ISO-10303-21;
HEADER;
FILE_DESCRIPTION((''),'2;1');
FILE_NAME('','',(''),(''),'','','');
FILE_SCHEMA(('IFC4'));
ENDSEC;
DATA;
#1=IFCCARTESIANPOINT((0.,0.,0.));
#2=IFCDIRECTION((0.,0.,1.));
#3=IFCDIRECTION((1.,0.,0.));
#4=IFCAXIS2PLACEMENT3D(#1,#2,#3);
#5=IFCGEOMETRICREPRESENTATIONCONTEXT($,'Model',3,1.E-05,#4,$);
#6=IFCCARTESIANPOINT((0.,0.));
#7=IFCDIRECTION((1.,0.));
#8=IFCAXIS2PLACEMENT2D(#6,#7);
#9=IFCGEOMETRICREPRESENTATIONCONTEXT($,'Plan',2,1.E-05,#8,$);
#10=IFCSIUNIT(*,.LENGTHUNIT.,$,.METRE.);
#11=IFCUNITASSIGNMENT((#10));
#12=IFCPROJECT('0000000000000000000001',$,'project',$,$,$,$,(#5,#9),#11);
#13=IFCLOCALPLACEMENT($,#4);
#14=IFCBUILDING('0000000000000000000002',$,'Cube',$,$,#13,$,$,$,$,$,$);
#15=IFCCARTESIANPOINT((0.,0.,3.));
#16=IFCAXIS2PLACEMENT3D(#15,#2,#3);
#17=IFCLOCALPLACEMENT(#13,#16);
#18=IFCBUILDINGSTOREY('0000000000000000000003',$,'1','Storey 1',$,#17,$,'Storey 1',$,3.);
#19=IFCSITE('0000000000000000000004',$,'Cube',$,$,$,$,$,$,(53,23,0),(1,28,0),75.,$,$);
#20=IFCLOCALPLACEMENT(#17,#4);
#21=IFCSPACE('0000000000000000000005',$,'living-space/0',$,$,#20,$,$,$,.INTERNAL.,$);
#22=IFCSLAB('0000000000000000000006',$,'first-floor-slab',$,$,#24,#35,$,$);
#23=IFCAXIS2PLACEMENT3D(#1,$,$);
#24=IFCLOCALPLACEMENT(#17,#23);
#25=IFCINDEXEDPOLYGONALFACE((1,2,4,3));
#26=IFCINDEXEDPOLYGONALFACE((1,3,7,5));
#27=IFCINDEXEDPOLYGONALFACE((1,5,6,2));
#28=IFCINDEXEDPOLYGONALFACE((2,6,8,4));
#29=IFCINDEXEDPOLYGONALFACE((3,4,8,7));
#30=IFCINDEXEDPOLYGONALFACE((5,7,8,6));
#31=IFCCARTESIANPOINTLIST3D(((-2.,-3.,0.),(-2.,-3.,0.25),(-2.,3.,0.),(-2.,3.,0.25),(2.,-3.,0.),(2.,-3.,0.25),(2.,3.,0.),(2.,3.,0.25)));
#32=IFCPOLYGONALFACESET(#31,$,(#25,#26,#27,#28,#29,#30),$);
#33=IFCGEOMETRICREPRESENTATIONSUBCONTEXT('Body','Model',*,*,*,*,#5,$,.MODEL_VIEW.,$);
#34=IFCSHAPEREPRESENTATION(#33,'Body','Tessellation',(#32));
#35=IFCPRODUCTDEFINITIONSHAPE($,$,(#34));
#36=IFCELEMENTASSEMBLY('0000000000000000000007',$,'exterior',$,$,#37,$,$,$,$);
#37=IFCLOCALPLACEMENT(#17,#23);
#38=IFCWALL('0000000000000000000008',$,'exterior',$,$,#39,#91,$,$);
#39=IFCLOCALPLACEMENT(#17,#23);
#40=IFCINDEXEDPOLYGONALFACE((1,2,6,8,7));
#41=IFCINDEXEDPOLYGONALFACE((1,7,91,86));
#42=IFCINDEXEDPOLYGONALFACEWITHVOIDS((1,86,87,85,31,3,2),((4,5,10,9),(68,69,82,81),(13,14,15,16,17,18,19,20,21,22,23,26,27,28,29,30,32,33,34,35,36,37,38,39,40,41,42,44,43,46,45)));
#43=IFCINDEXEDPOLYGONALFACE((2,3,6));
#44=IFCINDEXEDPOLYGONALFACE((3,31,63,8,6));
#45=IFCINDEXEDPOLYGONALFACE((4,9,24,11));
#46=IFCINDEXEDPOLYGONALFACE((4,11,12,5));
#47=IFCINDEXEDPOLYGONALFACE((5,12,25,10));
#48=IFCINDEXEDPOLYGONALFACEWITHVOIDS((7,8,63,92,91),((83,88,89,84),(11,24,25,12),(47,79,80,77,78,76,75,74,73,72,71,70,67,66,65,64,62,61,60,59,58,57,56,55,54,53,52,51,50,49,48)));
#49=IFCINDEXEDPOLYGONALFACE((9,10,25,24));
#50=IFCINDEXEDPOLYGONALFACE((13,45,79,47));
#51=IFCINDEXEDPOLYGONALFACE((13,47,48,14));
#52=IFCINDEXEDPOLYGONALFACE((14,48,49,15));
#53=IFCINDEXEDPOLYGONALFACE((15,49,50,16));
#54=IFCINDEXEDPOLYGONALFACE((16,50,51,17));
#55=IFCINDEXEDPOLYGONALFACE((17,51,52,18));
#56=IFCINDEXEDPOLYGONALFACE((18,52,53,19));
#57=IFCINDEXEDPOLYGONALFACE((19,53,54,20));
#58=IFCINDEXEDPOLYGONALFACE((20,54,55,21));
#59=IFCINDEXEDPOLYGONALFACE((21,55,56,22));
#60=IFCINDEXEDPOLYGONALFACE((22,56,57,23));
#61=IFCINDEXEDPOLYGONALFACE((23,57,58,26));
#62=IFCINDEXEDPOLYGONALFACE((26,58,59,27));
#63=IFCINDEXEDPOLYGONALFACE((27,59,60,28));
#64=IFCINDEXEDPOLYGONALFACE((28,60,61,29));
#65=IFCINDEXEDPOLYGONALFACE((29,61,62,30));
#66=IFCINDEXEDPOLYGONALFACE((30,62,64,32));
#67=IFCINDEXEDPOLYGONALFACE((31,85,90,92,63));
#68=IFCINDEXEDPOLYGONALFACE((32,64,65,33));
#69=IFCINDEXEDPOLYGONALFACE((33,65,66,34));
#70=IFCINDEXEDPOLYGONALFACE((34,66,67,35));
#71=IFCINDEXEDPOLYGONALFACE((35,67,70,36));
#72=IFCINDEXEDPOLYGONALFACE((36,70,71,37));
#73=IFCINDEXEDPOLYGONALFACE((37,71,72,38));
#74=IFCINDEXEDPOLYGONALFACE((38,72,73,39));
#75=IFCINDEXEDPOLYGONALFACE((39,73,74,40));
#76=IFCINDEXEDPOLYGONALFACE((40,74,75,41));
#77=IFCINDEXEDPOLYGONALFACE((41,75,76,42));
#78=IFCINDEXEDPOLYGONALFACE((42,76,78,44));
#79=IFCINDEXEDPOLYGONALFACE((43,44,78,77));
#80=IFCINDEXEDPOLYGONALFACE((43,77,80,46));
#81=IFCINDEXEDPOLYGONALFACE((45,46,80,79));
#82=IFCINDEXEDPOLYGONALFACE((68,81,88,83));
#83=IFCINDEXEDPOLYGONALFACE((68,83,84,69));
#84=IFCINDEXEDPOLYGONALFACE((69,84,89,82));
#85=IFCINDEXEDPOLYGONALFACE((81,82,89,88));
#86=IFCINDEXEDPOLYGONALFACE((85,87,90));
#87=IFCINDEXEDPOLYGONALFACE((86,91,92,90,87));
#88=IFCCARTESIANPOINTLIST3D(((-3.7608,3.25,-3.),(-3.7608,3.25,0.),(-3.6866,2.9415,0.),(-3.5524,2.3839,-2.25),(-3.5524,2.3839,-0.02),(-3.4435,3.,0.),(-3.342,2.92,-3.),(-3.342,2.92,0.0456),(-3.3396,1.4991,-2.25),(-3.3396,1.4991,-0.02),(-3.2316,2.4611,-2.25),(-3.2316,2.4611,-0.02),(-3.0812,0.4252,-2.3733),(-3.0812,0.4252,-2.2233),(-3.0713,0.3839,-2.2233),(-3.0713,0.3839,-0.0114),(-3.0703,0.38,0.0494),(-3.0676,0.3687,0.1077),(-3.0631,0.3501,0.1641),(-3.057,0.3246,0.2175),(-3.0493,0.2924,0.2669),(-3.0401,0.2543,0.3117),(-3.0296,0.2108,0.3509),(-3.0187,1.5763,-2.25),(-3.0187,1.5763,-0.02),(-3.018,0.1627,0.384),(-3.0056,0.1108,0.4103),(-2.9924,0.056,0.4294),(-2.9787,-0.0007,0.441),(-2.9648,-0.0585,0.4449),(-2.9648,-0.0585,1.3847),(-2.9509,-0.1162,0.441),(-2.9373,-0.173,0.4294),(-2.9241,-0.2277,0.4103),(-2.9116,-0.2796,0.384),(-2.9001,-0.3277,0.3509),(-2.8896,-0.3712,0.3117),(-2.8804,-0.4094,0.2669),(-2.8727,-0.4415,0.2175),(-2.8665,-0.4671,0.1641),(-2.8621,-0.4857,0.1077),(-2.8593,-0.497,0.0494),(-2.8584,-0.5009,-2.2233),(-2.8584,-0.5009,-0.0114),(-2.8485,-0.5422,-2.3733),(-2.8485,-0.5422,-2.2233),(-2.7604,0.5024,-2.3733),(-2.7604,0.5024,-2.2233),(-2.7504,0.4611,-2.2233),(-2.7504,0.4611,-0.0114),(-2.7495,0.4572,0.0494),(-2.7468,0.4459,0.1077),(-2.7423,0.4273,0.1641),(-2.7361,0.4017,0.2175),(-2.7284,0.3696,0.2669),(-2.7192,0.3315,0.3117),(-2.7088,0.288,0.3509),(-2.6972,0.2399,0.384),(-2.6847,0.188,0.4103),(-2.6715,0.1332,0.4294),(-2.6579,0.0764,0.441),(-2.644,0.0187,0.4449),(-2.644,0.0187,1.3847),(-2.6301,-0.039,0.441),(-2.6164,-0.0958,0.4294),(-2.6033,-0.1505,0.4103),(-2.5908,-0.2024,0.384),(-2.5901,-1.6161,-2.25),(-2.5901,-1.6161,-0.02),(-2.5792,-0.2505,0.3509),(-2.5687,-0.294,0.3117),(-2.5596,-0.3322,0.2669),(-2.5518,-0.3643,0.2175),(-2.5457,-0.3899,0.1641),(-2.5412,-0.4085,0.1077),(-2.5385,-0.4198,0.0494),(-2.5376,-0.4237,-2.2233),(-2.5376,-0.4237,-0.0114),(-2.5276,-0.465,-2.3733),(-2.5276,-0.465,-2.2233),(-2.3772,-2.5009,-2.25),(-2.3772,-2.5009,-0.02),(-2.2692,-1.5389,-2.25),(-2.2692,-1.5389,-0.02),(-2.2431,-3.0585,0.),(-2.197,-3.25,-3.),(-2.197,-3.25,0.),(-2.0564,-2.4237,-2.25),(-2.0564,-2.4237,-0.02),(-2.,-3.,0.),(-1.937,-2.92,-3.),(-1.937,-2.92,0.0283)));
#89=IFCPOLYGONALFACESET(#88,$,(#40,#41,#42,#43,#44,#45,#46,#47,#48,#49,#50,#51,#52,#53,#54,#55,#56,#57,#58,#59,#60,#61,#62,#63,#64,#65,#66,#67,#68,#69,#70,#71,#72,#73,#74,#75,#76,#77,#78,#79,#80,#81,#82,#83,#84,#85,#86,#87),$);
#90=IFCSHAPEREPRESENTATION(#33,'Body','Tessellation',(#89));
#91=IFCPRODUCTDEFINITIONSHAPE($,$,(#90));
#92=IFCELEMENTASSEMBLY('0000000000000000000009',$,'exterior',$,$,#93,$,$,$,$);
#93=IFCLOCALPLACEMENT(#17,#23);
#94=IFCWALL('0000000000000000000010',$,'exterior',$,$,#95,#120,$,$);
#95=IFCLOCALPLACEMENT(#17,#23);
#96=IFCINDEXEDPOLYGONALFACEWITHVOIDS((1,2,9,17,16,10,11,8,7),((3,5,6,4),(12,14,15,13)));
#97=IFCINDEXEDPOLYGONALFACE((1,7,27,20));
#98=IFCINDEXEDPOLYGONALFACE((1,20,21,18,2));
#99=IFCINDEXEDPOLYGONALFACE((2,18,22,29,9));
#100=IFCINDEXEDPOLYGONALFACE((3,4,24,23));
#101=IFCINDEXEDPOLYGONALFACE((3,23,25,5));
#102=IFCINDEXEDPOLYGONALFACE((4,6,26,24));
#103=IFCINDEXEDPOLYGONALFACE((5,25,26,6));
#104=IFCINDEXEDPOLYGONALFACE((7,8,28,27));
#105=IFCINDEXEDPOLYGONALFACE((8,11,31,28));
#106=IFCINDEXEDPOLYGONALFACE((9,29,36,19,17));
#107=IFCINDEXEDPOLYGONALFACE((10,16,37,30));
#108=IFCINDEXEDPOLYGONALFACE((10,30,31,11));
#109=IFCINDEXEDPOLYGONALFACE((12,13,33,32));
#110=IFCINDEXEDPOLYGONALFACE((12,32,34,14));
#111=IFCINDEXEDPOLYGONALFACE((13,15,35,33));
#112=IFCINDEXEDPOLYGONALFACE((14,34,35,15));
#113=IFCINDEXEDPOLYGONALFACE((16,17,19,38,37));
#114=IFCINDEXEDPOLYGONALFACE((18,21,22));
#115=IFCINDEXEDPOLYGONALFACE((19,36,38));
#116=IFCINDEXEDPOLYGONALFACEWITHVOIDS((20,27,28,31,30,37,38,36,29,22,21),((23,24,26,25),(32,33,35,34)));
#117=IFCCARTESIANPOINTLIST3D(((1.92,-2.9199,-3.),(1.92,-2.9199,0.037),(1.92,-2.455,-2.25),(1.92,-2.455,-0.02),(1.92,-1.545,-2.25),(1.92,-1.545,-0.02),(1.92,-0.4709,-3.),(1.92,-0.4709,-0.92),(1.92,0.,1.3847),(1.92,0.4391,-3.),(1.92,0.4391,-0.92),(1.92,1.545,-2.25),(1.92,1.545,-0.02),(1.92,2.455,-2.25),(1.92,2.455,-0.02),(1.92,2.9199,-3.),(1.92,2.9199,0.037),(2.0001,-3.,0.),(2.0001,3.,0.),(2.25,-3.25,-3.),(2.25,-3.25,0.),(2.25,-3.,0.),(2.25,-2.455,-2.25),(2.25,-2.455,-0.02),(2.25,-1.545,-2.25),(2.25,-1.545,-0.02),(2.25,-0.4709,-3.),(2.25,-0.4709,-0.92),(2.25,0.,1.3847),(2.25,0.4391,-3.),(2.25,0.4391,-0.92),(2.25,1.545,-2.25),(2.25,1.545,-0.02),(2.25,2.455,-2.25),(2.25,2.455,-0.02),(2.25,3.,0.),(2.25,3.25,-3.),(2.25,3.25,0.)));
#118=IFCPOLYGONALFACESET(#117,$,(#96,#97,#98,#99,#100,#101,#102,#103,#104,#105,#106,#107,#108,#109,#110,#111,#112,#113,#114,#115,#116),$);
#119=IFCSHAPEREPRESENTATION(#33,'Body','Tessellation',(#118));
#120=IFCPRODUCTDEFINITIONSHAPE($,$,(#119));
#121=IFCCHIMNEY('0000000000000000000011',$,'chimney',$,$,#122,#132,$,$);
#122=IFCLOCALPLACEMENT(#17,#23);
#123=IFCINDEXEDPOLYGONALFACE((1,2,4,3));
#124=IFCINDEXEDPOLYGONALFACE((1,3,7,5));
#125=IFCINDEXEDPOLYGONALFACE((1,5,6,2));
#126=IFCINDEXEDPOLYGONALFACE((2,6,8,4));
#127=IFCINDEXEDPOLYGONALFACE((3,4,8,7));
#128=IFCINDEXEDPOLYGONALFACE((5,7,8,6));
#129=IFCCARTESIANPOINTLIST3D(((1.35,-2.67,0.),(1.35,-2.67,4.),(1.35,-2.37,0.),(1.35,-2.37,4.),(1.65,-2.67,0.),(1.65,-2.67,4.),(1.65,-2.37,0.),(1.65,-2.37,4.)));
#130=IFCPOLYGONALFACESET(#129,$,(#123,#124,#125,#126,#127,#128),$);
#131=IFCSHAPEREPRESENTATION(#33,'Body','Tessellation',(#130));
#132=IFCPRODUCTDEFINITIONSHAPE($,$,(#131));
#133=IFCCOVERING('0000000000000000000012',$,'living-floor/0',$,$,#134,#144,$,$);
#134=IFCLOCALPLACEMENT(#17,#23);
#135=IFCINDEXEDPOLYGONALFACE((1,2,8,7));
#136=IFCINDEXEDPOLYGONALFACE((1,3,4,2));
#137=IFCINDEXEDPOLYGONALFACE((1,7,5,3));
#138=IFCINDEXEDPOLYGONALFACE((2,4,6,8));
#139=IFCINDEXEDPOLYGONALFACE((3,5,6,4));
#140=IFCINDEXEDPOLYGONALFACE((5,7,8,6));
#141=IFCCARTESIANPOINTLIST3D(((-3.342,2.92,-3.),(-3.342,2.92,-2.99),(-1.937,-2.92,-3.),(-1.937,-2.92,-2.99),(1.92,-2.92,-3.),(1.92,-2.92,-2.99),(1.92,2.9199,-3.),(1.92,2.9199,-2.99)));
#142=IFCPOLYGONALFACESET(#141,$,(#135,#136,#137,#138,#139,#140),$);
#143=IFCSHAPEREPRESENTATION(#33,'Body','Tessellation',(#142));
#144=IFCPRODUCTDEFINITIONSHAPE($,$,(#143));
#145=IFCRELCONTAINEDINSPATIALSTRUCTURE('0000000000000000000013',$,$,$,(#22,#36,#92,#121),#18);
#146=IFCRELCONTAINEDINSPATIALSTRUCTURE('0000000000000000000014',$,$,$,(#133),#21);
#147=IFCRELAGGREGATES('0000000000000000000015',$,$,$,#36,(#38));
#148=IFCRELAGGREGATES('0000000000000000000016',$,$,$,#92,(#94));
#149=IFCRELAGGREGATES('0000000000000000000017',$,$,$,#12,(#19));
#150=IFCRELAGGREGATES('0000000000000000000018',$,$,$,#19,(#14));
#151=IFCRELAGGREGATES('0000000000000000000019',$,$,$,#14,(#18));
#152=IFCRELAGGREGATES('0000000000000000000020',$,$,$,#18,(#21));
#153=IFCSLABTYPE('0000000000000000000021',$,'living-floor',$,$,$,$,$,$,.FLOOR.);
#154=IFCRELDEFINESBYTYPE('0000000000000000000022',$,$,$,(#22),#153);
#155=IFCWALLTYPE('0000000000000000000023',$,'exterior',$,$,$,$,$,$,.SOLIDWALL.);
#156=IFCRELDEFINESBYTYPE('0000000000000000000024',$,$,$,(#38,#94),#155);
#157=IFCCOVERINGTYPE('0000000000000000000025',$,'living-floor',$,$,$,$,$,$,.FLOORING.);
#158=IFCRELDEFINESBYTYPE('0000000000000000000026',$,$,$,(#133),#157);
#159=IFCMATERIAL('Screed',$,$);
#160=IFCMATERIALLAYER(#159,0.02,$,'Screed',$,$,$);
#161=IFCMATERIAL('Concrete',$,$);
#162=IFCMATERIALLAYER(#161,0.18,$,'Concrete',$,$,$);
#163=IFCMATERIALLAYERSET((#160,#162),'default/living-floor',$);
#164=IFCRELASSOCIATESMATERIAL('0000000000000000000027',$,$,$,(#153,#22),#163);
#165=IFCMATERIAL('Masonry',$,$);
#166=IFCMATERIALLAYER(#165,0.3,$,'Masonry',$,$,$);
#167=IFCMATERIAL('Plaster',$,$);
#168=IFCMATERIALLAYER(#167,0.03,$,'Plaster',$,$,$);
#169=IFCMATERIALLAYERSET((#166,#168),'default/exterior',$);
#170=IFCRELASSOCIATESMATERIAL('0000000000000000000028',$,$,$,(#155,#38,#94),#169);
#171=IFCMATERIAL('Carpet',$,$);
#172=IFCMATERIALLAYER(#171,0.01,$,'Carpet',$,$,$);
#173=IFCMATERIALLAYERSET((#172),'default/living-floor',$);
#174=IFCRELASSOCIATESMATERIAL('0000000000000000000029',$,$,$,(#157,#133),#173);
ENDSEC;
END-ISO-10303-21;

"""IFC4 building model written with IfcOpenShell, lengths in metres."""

from ifc_helpers import new_model, si_unit, frame, origin, origin_with_axes, origin_2d_with_axis, place, context, subcontext, project, spatial, polyline, line, indexed_curve, outline, extrude, clip, bounded_halfspace, source, transform, mapped, material, layer, layer_set, layer_usage, type_object, element, aggregate, save


model = new_model("IFC4")

# Units and contexts
model_context = context("Model", 3, precision=1e-05, world=origin_with_axes())
plan_context = context("Plan", 2, precision=1e-05, world=origin_2d_with_axis())
body_context_1 = subcontext(model_context, "Body", "Model", "MODEL_VIEW")
ifc_project = project(units=[si_unit("LENGTHUNIT", "METRE")], contexts=[model_context, plan_context])

# Site, building, storey
site = spatial("IfcSite", under=ifc_project, Name="Cube", RefLatitude=(53, 23, 0), RefLongitude=(1, 28, 0), RefElevation=75.0)
building_placement = place(None, origin_with_axes())
building = spatial("IfcBuilding", under=site, at=building_placement, Name="Cube")
storey_placement = place(building_placement, frame((0.0, 0.0, 3.0), z_axis=(0.0, 0.0, 1.0), x_axis=(1.0, 0.0, 0.0)))
storey = spatial("IfcBuildingStorey", under=building, at=storey_placement, Name="1", Description="Storey 1", LongName="Storey 1", Elevation=3.0)

# Slab
ifc_material_1 = material(Name="Screed")
ifc_layer_1 = layer(ifc_material_1, 0.02, Name="Screed")
ifc_material_2 = material(Name="Concrete")
ifc_layer_2 = layer(ifc_material_2, 0.18, Name="Concrete")
ifc_layer_set_1 = layer_set([ifc_layer_1, ifc_layer_2], Name="default/living-floor")
ifc_layer_usage_1 = layer_usage(ifc_layer_set_1, "AXIS3", "POSITIVE", 0.0)
slab_type = type_object("IfcSlabType", Name="living-floor", PredefinedType="FLOOR", material=ifc_layer_set_1)
slab_placement = place(storey_placement, frame((-2.0, -3.0, 0.0), z_axis=(0.0, 0.0, 1.0), x_axis=(1.0, 0.0, 0.0)))
element("IfcSlab", 1, at=slab_placement, inside=storey, type_object=slab_type, material=ifc_layer_usage_1, Name="first-floor-slab", context=body_context_1, shape_type="SweptSolid", body=[
    extrude(outline(indexed_curve([(0.0, 0.0), (4.0, 0.0), (4.0, 6.0), (0.0, 6.0)])), None, (0.0, 0.0, 1.0), 0.25),
])

# Element assemblies, walls, openings
assembly_1_placement = place(storey_placement, frame((-3.4435, 3.0, 0.0), z_axis=(0.0, 0.0, 1.0), x_axis=(0.233915, -0.972257, 0.0)))
assembly_1 = element("IfcElementAssembly", 2, at=assembly_1_placement, inside=storey, Name="exterior")
ifc_material_3 = material(Name="Masonry")
ifc_layer_3 = layer(ifc_material_3, 0.3, Name="Masonry")
ifc_material_4 = material(Name="Plaster")
ifc_layer_4 = layer(ifc_material_4, 0.03, Name="Plaster")
ifc_layer_set_2 = layer_set([ifc_layer_3, ifc_layer_4], Name="default/exterior")
ifc_layer_usage_2 = layer_usage(ifc_layer_set_2, "AXIS2", "POSITIVE", -0.25)
wall_type = type_object("IfcWallType", Name="exterior", PredefinedType="SOLIDWALL", material=ifc_layer_set_2)
wall_1_placement = place(assembly_1_placement, frame((0.0, 0.0, -3.0), z_axis=(0.0, 0.0, 1.0), x_axis=(1.0, 0.0, 0.0)))
wall_1 = element("IfcWall", 3, at=wall_1_placement, type_object=wall_type, material=ifc_layer_usage_2, Name="exterior", context=body_context_1, shape_type="Clipping", body=[
    clip(clip(clip(clip(extrude(outline(polyline([(0.1015, 0.08), (-0.3173, -0.25), (6.3682, -0.25), (6.1082, 0.08), (0.1015, 0.08)])), origin(), (0.0, 0.0, 1.0), 4.385), bounded_halfspace(frame((6.1712, 0.0, 3.0), z_axis=(0.409415, 0.0, 0.912348), x_axis=(0.0, -1.0, 0.0)), False, origin(), polyline([(6.1712, -1.0), (3.0856, -1.0), (3.0856, 1.0), (6.1712, 1.0), (6.1712, -1.0)]))), bounded_halfspace(frame((6.1712, 0.0, 3.0), z_axis=(0.0, 0.0, 1.0), x_axis=(0.0, 1.0, 0.0)), False, origin(), polyline([(6.1712, 1.0), (7.1712, 1.0), (7.1712, -1.0), (6.1712, -1.0), (6.1712, 1.0)]))), bounded_halfspace(frame((3.0856, 0.0, 4.3847), z_axis=(-0.409415, 0.0, 0.912348), x_axis=(0.0, -1.0, 0.0)), False, origin(), polyline([(3.0856, -1.0), (0.0, -1.0), (0.0, 1.0), (3.0856, 1.0), (3.0856, -1.0)]))), bounded_halfspace(frame((0.0, 0.0, 3.0), z_axis=(0.0, 0.0, 1.0), x_axis=(0.0, -1.0, 0.0)), False, origin(), polyline([(0.0, -1.0), (-1.0, -1.0), (-1.0, 1.0), (0.0, 1.0), (0.0, -1.0)]))),
])
opening_1_placement = place(wall_1_placement, frame((0.5735, -0.25, 0.75), z_axis=(0.0, 0.0, 1.0), x_axis=(1.0, 0.0, 0.0)))
element("IfcOpeningElement", 4, at=opening_1_placement, cuts=wall_1, PredefinedType="OPENING", context=body_context_1, shape_type="SweptSolid", body=[
    extrude(outline(polyline([(0.0, -0.02), (0.91, -0.02), (0.91, 0.35), (0.0, 0.35), (0.0, -0.02)])), origin(), (0.0, 0.0, 1.0), 2.23),
])
opening_2_placement = place(wall_1_placement, frame((2.6306, -0.25, 0.75), z_axis=(0.0, 0.0, 1.0), x_axis=(1.0, 0.0, 0.0)))
element("IfcOpeningElement", 5, at=opening_2_placement, cuts=wall_1, PredefinedType="OPENING", context=body_context_1, shape_type="SweptSolid", body=[
    extrude(outline(polyline([(0.1333, 2.5617), (0.1781, 2.6009), (0.2275, 2.634), (0.2809, 2.6603), (0.3373, 2.6794), (0.3956, 2.691), (0.455, 2.6949), (0.5144, 2.691), (0.5727, 2.6794), (0.6291, 2.6603), (0.6825, 2.634), (0.7319, 2.6009), (0.7767, 2.5617), (0.8159, 2.5169), (0.849, 2.4675), (0.8753, 2.4141), (0.8944, 2.3577), (0.906, 2.2994), (0.91, 2.2386), (0.91, 2.2069), (0.91, 0.0267), (0.9525, 0.0267), (0.9525, -0.1233), (-0.0425, -0.1233), (-0.0425, 0.0267), (0.0, 0.0267), (0.0, 2.2069), (0.0, 2.2386), (0.004, 2.2994), (0.0156, 2.3577), (0.0347, 2.4141), (0.061, 2.4675), (0.0941, 2.5169), (0.1333, 2.5617)])), frame((0.0, -0.02, 0.0), z_axis=(0.0, -1.0, 0.0), x_axis=(1.0, 0.0, 0.0)), (0.0, 0.0, -1.0), 0.37),
])
opening_3_placement = place(wall_1_placement, frame((4.6877, -0.25, 0.75), z_axis=(0.0, 0.0, 1.0), x_axis=(1.0, 0.0, 0.0)))
element("IfcOpeningElement", 6, at=opening_3_placement, cuts=wall_1, PredefinedType="OPENING", context=body_context_1, shape_type="SweptSolid", body=[
    extrude(outline(polyline([(0.0, -0.02), (0.91, -0.02), (0.91, 0.35), (0.0, 0.35), (0.0, -0.02)])), origin(), (0.0, 0.0, 1.0), 2.23),
])
aggregate(assembly_1, [wall_1])
assembly_2_placement = place(storey_placement, frame((2.0, -3.0, 0.0), z_axis=(0.0, 0.0, 1.0), x_axis=(0.0, 1.0, 0.0)))
assembly_2 = element("IfcElementAssembly", 7, at=assembly_2_placement, inside=storey, Name="exterior")
ifc_layer_usage_3 = layer_usage(ifc_layer_set_2, "AXIS2", "POSITIVE", -0.25)
wall_2_placement = place(assembly_2_placement, frame((0.0, 0.0, -3.0), z_axis=(0.0, 0.0, 1.0), x_axis=(1.0, 0.0, 0.0)))
wall_2 = element("IfcWall", 8, at=wall_2_placement, type_object=wall_type, material=ifc_layer_usage_3, Name="exterior", context=body_context_1, shape_type="Clipping", body=[
    clip(clip(clip(clip(extrude(outline(polyline([(0.0801, 0.08), (-0.25, -0.25), (6.25, -0.25), (5.9199, 0.08), (0.0801, 0.08)])), origin(), (0.0, 0.0, 1.0), 4.385), bounded_halfspace(frame((6.0, 0.0, 3.0), z_axis=(0.419069, 0.0, 0.907954), x_axis=(0.0, -1.0, 0.0)), False, origin(), polyline([(6.0, -1.0), (3.0, -1.0), (3.0, 1.0), (6.0, 1.0), (6.0, -1.0)]))), bounded_halfspace(frame((6.0, 0.0, 3.0), z_axis=(0.0, 0.0, 1.0), x_axis=(0.0, 1.0, 0.0)), False, origin(), polyline([(6.0, 1.0), (7.0, 1.0), (7.0, -1.0), (6.0, -1.0), (6.0, 1.0)]))), bounded_halfspace(frame((3.0, 0.0, 4.3847), z_axis=(-0.419069, 0.0, 0.907954), x_axis=(0.0, -1.0, 0.0)), False, origin(), polyline([(3.0, -1.0), (0.0, -1.0), (0.0, 1.0), (3.0, 1.0), (3.0, -1.0)]))), bounded_halfspace(frame((0.0, 0.0, 3.0), z_axis=(0.0, 0.0, 1.0), x_axis=(0.0, -1.0, 0.0)), False, origin(), polyline([(0.0, -1.0), (-1.0, -1.0), (-1.0, 1.0), (0.0, 1.0), (0.0, -1.0)]))),
])
opening_4_placement = place(wall_2_placement, frame((0.545, -0.25, 0.75), z_axis=(0.0, 0.0, 1.0), x_axis=(1.0, 0.0, 0.0)))
element("IfcOpeningElement", 9, at=opening_4_placement, cuts=wall_2, PredefinedType="OPENING", context=body_context_1, shape_type="SweptSolid", body=[
    extrude(outline(polyline([(0.0, -0.02), (0.91, -0.02), (0.91, 0.35), (0.0, 0.35), (0.0, -0.02)])), origin(), (0.0, 0.0, 1.0), 2.23),
])
opening_5_placement = place(wall_2_placement, frame((4.545, -0.25, 0.75), z_axis=(0.0, 0.0, 1.0), x_axis=(1.0, 0.0, 0.0)))
element("IfcOpeningElement", 10, at=opening_5_placement, cuts=wall_2, PredefinedType="OPENING", context=body_context_1, shape_type="SweptSolid", body=[
    extrude(outline(polyline([(0.0, -0.02), (0.91, -0.02), (0.91, 0.35), (0.0, 0.35), (0.0, -0.02)])), origin(), (0.0, 0.0, 1.0), 2.23),
])
shared_shape_1 = source(origin_with_axes(), body_context_1, "Body", "SweptSolid", [
    extrude(outline(indexed_curve([(0.0, 0.0), (0.91, 0.0), (0.91, 2.08), (0.0, 2.08)], segments=[line(1, 2, 3, 4, 1)])), frame((0.0, -0.6, 0.0), z_axis=(0.0, -1.0, 0.0), x_axis=(1.0, 0.0, 0.0)), (0.0, 0.0, -1.0), 1.2),
])
opening_6_placement = place(wall_2_placement, frame((2.5291, -0.25, 0.0), z_axis=(0.0, 0.0, 1.0), x_axis=(1.0, 0.0, 0.0)))
element("IfcOpeningElement", 11, at=opening_6_placement, cuts=wall_2, PredefinedType="OPENING", context=body_context_1, shape_type="MappedRepresentation", body=[
    mapped(shared_shape_1, transform((0.0, 0.0, 0.0), x_axis=(1.0, 0.0, 0.0), y_axis=(0.0, 1.0, 0.0), z_axis=(0.0, 0.0, 1.0), scale=1.0)),
])
aggregate(assembly_2, [wall_2])

# Chimney
chimney_placement = place(storey_placement, frame((1.35, -2.67, 0.0), z_axis=(0.0, 0.0, 1.0), x_axis=(1.0, 0.0, 0.0)))
element("IfcChimney", 12, at=chimney_placement, inside=storey, Name="chimney", context=body_context_1, shape_type="SweptSolid", body=[
    extrude(outline(indexed_curve([(0.0, 0.0), (0.3, 0.0), (0.3, 0.3), (0.0, 0.3)])), None, (0.0, 0.0, 1.0), 4.0),
])

# Shared definitions
space_placement = place(storey_placement, origin_with_axes())
space = spatial("IfcSpace", under=storey, at=space_placement, Name="living-space/0", PredefinedType="INTERNAL")

# Covering
ifc_material_5 = material(Name="Carpet")
ifc_layer_5 = layer(ifc_material_5, 0.01, Name="Carpet")
ifc_layer_set_3 = layer_set([ifc_layer_5], Name="default/living-floor")
ifc_layer_usage_4 = layer_usage(ifc_layer_set_3, "AXIS3", "POSITIVE", 0.0)
covering_type = type_object("IfcCoveringType", Name="living-floor", PredefinedType="FLOORING", material=ifc_layer_set_3)
covering_placement = place(space_placement, frame((0.0, 0.0, -3.0), z_axis=(0.0, 0.0, 1.0), x_axis=(1.0, 0.0, 0.0)))
element("IfcCovering", 13, at=covering_placement, inside=space, type_object=covering_type, material=ifc_layer_usage_4, Name="living-floor/0", context=body_context_1, shape_type="SweptSolid", body=[
    extrude(outline(polyline([(1.92, 2.9199), (-3.342, 2.92), (-1.937, -2.92), (1.92, -2.92), (1.92, 2.9199)])), origin_with_axes(), (0.0, 0.0, 1.0), 0.01),
])

save(model, "model.ifc")
